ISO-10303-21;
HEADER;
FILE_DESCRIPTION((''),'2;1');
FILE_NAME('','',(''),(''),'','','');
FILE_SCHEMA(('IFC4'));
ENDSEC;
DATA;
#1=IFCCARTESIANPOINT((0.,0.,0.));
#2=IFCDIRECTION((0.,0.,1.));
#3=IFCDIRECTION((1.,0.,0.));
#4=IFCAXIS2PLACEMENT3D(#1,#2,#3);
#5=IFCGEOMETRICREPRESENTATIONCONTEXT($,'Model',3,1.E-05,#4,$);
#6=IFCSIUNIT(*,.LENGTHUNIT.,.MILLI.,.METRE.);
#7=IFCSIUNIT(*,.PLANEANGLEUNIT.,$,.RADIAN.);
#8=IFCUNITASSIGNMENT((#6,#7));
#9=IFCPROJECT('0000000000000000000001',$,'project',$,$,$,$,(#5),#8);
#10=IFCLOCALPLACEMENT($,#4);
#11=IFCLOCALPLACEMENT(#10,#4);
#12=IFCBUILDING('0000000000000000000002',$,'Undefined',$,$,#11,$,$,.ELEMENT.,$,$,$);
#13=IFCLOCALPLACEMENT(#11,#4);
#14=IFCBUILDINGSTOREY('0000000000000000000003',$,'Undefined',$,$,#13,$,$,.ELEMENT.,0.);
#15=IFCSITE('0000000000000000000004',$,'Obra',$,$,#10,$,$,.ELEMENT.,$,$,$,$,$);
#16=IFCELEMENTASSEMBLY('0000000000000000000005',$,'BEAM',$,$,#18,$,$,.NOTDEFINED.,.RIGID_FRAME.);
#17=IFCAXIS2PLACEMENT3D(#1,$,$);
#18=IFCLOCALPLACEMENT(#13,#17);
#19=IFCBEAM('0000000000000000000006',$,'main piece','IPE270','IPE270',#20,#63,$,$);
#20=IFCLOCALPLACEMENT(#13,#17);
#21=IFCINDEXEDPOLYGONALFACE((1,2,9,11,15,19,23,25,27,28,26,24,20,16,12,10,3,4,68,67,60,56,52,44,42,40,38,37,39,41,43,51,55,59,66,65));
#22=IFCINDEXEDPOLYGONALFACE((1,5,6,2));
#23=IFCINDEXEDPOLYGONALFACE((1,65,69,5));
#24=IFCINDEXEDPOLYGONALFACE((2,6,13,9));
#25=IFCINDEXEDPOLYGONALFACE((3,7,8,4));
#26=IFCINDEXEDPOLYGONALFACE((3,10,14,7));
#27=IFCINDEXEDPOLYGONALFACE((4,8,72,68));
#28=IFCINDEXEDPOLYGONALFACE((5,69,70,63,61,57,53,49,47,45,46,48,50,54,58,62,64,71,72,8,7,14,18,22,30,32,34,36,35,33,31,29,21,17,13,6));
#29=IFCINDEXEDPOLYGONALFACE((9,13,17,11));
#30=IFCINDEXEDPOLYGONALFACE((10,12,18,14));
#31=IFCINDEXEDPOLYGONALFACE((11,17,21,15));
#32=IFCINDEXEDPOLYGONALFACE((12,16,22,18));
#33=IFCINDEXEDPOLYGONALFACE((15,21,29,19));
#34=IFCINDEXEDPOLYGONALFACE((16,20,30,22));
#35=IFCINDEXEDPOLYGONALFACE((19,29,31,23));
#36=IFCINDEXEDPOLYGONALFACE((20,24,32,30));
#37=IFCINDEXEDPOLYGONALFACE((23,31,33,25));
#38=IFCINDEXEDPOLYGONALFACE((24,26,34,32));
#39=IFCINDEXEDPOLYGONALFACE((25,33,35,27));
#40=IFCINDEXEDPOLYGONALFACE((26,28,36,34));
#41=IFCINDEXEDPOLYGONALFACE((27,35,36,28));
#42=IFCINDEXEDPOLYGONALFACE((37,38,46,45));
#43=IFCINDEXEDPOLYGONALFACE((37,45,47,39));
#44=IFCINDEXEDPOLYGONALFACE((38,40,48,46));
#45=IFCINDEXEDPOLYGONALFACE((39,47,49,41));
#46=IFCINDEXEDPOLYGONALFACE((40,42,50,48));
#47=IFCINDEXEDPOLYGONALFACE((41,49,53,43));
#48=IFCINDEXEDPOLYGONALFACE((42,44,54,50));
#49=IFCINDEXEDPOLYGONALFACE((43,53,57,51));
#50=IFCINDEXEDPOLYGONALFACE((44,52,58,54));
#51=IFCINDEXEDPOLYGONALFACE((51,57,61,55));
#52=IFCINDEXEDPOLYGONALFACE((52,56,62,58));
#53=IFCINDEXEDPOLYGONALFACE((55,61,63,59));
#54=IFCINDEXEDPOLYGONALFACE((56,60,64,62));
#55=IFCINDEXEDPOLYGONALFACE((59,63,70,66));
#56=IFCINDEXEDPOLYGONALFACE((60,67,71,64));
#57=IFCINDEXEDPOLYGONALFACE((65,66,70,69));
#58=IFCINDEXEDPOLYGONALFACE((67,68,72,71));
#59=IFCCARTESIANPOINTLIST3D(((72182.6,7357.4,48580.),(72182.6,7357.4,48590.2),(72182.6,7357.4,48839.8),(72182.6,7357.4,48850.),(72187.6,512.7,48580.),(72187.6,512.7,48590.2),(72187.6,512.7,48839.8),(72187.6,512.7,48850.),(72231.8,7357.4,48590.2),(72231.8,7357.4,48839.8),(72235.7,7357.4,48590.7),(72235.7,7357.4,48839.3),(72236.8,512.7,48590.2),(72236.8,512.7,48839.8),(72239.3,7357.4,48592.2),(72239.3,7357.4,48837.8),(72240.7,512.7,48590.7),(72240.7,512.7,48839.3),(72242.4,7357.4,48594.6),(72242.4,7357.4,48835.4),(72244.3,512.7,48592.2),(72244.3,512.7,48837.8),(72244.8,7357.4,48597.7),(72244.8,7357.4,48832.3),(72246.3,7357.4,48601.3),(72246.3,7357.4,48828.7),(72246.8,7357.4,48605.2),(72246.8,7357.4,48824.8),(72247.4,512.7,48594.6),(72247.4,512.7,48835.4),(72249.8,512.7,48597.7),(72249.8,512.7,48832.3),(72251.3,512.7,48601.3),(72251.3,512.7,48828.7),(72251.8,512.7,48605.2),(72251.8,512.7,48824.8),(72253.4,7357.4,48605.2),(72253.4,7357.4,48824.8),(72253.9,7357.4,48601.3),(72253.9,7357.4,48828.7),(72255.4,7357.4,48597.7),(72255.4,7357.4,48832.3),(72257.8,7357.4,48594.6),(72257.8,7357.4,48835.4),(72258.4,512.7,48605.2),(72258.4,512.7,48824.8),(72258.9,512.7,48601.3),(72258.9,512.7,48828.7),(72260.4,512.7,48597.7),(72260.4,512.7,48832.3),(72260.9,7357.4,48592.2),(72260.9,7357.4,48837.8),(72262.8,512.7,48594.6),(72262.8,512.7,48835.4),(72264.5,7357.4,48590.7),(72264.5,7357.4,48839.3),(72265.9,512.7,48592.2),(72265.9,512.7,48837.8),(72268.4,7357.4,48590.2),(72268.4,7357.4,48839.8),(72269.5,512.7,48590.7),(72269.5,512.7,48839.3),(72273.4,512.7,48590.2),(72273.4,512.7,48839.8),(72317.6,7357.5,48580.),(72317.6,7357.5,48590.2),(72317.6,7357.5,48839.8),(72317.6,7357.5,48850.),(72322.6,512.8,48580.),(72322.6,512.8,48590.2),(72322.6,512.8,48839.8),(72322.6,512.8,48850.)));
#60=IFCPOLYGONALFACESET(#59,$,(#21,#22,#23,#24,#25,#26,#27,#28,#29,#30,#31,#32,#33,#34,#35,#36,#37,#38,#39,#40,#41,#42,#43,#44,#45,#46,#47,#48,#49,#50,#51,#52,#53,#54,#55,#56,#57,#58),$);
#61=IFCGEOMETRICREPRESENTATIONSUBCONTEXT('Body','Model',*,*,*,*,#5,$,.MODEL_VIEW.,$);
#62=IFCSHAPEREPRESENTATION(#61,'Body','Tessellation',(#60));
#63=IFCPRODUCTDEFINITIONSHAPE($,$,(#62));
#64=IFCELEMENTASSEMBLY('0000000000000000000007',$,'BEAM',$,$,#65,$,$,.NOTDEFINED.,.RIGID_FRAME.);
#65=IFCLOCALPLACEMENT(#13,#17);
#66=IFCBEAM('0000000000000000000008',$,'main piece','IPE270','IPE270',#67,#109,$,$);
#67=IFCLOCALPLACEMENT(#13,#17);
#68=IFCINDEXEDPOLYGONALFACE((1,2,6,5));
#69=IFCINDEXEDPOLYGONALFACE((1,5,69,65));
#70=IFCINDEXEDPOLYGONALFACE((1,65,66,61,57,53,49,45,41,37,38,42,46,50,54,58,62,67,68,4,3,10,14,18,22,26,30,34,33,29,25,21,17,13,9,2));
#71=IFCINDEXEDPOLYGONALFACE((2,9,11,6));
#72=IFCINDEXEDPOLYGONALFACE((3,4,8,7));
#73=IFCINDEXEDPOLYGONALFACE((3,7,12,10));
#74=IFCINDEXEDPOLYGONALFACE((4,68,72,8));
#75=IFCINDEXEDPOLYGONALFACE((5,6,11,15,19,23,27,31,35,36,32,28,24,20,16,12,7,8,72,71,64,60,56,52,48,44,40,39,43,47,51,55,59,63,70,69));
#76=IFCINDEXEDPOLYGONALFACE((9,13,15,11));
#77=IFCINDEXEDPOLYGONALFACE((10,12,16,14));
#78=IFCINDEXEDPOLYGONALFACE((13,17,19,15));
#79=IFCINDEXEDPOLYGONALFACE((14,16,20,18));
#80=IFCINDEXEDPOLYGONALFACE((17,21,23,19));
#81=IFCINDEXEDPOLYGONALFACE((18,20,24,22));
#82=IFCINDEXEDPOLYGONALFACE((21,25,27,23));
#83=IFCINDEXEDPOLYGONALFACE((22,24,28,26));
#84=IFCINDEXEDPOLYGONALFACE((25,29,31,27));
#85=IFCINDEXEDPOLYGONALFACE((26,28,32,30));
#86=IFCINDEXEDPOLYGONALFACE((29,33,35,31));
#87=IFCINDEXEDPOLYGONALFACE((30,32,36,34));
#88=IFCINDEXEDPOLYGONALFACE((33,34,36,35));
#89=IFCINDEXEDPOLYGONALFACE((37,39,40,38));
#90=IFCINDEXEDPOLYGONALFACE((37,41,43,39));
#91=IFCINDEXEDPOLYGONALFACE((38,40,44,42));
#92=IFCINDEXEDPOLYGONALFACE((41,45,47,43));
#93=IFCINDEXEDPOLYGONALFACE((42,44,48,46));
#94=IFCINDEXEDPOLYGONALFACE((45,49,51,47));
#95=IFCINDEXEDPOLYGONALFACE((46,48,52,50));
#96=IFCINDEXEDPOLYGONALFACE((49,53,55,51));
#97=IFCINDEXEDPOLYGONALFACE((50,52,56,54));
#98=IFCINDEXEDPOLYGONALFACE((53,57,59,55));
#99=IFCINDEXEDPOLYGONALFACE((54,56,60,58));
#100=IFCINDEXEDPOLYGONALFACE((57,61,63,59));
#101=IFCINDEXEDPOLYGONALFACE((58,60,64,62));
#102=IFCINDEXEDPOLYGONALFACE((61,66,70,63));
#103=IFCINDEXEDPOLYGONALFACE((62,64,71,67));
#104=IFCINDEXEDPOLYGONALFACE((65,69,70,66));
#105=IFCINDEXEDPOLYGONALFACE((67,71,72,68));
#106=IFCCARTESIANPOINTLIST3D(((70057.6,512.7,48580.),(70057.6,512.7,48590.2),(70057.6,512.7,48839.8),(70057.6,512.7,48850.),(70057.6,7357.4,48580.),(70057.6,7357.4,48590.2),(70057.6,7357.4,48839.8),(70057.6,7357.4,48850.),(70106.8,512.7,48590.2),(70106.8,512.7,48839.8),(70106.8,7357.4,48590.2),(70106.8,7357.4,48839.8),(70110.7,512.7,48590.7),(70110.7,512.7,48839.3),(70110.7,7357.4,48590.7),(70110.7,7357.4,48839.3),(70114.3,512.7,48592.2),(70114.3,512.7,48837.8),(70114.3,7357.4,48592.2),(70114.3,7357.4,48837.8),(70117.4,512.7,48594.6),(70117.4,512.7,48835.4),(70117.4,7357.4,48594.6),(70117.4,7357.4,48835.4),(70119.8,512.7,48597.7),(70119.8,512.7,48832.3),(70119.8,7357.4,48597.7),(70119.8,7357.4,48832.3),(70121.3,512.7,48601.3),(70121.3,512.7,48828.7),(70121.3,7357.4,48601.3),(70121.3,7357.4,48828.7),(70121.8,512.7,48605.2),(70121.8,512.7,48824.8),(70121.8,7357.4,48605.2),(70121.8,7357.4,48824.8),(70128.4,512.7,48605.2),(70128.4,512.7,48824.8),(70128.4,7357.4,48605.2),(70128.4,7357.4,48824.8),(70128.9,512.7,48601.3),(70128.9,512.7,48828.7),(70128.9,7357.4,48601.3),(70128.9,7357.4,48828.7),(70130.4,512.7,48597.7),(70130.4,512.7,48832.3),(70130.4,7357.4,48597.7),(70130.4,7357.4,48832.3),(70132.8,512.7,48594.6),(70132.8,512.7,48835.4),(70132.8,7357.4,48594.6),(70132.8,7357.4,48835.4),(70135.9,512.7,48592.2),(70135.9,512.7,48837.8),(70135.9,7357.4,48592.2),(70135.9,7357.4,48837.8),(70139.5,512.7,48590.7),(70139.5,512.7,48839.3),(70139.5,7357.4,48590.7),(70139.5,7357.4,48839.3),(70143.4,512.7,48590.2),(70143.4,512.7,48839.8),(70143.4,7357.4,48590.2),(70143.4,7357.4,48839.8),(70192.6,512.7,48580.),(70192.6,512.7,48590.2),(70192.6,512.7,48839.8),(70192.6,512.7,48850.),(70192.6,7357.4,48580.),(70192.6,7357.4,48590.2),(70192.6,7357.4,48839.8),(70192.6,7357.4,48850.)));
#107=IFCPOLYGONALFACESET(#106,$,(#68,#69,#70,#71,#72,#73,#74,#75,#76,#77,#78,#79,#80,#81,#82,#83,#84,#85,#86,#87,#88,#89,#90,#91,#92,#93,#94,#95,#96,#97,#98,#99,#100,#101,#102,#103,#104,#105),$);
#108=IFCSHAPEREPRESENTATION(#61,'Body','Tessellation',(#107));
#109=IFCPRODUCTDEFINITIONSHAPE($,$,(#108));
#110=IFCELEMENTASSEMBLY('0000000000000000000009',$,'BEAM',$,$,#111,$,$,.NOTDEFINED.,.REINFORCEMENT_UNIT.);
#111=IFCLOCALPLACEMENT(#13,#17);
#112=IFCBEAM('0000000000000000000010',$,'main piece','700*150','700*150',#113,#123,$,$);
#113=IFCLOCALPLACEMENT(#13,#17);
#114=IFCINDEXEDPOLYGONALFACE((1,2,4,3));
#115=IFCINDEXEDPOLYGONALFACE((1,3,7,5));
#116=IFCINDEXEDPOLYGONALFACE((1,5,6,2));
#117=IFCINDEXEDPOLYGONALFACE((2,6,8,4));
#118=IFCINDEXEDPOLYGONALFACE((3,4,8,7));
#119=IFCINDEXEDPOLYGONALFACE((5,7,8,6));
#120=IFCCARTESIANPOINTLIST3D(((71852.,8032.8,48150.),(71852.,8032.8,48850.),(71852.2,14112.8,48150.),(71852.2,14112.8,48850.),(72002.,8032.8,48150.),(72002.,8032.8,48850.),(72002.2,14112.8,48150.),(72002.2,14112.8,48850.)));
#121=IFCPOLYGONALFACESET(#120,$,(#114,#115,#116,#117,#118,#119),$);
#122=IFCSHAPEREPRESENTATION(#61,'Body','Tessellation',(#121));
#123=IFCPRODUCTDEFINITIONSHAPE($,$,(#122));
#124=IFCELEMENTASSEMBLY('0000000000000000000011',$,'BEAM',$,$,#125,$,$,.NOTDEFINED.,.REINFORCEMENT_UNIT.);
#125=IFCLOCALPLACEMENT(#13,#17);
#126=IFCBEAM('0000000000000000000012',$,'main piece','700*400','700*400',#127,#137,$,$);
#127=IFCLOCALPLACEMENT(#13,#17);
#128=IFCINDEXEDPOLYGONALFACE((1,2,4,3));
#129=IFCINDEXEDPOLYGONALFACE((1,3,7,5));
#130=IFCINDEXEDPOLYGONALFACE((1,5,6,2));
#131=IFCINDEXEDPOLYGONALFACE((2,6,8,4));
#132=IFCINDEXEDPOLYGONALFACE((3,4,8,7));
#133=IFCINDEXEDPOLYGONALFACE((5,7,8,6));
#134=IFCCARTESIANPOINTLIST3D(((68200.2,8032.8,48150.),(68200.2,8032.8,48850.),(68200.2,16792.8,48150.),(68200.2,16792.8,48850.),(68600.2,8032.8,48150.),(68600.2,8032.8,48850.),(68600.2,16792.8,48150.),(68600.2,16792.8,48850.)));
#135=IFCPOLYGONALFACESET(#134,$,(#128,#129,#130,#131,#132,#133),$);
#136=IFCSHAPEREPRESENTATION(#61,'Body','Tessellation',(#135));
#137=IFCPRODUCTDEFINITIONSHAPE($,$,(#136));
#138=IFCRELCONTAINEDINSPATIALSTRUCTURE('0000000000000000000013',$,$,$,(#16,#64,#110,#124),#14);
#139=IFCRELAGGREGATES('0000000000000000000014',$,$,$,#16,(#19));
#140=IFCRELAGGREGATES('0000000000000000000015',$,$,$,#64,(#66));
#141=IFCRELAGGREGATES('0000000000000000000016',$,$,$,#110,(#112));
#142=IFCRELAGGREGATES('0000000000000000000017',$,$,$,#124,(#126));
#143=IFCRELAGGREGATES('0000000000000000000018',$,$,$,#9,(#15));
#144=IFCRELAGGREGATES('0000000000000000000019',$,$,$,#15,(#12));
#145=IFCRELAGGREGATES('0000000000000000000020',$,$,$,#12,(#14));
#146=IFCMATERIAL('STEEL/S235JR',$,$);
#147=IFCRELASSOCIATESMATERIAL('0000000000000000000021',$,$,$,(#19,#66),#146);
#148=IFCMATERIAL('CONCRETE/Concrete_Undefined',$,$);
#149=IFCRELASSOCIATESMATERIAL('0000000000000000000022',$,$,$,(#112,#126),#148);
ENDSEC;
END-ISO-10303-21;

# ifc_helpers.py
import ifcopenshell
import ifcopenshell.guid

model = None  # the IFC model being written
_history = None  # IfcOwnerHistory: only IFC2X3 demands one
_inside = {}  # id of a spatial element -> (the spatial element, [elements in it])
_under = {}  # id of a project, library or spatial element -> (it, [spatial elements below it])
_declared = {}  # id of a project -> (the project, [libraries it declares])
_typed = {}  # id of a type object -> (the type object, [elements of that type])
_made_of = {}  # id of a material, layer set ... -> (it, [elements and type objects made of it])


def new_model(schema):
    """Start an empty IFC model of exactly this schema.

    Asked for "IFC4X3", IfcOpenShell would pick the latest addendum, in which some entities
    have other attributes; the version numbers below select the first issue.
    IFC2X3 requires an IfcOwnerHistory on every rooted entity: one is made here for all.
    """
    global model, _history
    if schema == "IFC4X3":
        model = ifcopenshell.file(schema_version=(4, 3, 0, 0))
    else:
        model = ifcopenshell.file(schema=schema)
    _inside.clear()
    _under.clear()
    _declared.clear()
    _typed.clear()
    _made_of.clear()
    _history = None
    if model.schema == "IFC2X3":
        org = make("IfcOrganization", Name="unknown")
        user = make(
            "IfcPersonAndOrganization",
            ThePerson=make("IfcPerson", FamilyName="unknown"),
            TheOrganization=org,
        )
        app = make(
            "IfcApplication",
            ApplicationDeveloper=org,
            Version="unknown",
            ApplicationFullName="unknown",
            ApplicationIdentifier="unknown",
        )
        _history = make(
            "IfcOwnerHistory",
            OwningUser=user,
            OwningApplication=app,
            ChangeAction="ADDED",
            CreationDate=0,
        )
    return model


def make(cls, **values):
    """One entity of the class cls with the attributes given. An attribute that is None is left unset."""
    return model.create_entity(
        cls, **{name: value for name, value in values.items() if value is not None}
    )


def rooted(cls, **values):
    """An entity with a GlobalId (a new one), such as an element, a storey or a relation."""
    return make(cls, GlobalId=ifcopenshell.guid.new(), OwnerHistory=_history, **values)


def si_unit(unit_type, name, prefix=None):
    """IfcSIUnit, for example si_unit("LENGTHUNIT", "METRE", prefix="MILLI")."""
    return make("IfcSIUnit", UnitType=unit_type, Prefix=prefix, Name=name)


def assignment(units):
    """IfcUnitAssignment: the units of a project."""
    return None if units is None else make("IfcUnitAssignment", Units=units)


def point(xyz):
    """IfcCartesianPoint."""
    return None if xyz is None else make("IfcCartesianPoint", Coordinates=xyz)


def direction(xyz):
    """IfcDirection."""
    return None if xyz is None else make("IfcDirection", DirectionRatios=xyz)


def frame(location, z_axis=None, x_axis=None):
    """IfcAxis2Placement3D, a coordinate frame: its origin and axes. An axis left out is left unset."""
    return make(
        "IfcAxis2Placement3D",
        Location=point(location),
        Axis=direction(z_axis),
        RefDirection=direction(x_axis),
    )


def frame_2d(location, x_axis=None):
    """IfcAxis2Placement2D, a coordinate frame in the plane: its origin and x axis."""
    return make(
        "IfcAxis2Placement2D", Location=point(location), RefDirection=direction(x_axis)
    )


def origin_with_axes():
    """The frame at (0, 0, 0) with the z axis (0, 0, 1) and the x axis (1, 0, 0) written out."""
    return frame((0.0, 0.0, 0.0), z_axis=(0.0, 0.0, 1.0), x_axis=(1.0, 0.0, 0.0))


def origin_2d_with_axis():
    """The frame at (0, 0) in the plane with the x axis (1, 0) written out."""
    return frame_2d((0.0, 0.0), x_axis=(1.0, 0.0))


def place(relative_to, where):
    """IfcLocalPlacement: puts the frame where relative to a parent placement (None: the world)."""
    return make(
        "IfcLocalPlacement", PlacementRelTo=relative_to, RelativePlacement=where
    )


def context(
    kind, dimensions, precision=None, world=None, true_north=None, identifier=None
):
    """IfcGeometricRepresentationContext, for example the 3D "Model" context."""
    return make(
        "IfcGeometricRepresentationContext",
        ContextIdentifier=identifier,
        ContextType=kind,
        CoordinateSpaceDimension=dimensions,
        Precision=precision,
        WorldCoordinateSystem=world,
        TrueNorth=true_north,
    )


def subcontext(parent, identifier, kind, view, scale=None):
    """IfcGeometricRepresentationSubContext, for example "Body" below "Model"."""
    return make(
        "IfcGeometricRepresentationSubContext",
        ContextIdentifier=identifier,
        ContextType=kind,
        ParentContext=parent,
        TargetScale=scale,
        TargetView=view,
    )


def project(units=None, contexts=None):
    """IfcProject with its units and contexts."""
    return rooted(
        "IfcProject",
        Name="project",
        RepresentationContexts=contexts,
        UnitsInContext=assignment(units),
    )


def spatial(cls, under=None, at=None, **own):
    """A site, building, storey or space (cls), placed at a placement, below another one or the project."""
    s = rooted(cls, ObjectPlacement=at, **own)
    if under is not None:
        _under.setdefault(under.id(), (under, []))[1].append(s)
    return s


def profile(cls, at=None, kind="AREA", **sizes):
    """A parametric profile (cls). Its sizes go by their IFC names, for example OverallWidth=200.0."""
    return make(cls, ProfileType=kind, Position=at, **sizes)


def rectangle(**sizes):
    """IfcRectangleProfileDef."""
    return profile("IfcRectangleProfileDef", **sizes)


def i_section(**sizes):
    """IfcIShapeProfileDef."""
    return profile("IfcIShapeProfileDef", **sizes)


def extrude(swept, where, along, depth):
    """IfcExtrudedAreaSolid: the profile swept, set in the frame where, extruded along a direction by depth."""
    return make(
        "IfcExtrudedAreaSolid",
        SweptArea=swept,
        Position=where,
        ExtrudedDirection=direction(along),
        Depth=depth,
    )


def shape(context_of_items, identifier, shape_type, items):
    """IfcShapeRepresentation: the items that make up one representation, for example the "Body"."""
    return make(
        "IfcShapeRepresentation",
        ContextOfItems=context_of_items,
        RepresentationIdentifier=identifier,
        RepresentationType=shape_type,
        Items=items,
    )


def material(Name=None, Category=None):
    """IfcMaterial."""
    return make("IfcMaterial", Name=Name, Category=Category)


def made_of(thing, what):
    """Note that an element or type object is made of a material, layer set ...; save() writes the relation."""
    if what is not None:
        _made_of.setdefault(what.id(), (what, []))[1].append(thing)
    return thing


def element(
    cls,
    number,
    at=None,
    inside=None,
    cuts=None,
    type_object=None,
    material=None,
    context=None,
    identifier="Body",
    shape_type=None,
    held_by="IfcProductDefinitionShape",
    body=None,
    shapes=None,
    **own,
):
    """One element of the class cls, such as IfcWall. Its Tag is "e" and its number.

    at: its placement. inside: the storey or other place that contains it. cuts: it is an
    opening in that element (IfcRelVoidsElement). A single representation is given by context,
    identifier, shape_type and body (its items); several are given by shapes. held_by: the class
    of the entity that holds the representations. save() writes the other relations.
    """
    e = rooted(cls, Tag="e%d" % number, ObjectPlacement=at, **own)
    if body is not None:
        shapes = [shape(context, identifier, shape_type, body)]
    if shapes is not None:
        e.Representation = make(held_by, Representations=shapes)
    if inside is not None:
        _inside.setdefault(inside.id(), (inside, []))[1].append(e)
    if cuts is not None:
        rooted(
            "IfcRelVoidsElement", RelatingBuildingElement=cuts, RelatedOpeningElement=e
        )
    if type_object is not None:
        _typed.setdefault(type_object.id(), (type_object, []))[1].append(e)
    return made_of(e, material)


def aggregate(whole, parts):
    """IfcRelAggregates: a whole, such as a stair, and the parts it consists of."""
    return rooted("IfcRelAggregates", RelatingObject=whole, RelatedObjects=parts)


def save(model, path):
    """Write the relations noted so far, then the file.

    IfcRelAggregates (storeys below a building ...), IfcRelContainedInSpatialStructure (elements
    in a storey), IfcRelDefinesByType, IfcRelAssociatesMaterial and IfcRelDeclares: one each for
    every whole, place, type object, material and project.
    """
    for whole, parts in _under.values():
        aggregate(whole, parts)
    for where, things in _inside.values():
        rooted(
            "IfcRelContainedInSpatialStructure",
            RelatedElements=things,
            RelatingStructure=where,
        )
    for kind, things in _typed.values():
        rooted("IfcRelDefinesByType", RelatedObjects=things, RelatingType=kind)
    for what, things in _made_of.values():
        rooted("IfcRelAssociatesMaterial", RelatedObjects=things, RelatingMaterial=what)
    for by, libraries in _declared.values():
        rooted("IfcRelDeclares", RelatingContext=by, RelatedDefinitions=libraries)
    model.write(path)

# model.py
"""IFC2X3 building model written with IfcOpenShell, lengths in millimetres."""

from ifc_helpers import new_model, si_unit, frame, origin_with_axes, origin_2d_with_axis, place, context, subcontext, project, spatial, rectangle, i_section, extrude, material, element, aggregate, save


model = new_model("IFC2X3")

# Units and contexts
model_context = context("Model", 3, precision=1e-05, world=origin_with_axes())
body_context = subcontext(model_context, "Body", "Model", "MODEL_VIEW")
ifc_project = project(units=[si_unit("LENGTHUNIT", "METRE", prefix="MILLI"), si_unit("PLANEANGLEUNIT", "RADIAN")], contexts=[model_context])

# Site, building, storey
site_placement = place(None, origin_with_axes())
site = spatial("IfcSite", under=ifc_project, at=site_placement, Name="Obra", CompositionType="ELEMENT")
building_placement = place(site_placement, origin_with_axes())
building = spatial("IfcBuilding", under=site, at=building_placement, Name="Undefined", CompositionType="ELEMENT")
storey_placement = place(building_placement, origin_with_axes())
storey = spatial("IfcBuildingStorey", under=building, at=storey_placement, Name="Undefined", CompositionType="ELEMENT", Elevation=0.0)

# Shared definitions
ifc_material_1 = material(Name="STEEL/S235JR")

# Element assemblies, beams
ifc_material_2 = material(Name="CONCRETE/Concrete_Undefined")
assembly_1_placement = place(storey_placement, origin_with_axes())
assembly_1 = element("IfcElementAssembly", 1, at=assembly_1_placement, inside=storey, Name="BEAM", AssemblyPlace="NOTDEFINED", PredefinedType="RIGID_FRAME")
beam_1_placement = place(assembly_1_placement, frame((72250.1, 7357.4, 48715.0), z_axis=(0.0, 0.0, 1.0), x_axis=(0.000731, -1.0, 0.0)))
beam_1 = element("IfcBeam", 2, at=beam_1_placement, material=ifc_material_1, Name="main piece", Description="IPE270", ObjectType="IPE270", context=body_context, shape_type="SweptSolid", body=[
    extrude(i_section(OverallWidth=135.0, OverallDepth=270.0, WebThickness=6.6, FlangeThickness=10.2, FilletRadius=15.0, at=origin_2d_with_axis()), frame((6844.7, 0.0, 0.0), z_axis=(-1.0, 0.0, 0.0), x_axis=(0.0, -1.0, 0.0)), (0.0, 0.0, 1.0), 6844.7),
])
aggregate(assembly_1, [beam_1])
assembly_2_placement = place(storey_placement, origin_with_axes())
assembly_2 = element("IfcElementAssembly", 3, at=assembly_2_placement, inside=storey, Name="BEAM", AssemblyPlace="NOTDEFINED", PredefinedType="RIGID_FRAME")
beam_2_placement = place(assembly_2_placement, frame((70125.1, 512.7, 48715.0), z_axis=(0.0, 0.0, 1.0), x_axis=(0.0, 1.0, 0.0)))
beam_2 = element("IfcBeam", 4, at=beam_2_placement, material=ifc_material_1, Name="main piece", Description="IPE270", ObjectType="IPE270", context=body_context, shape_type="SweptSolid", body=[
    extrude(i_section(OverallWidth=135.0, OverallDepth=270.0, WebThickness=6.6, FlangeThickness=10.2, FilletRadius=15.0, at=origin_2d_with_axis()), frame((6844.7, 0.0, 0.0), z_axis=(-1.0, 0.0, 0.0), x_axis=(0.0, -1.0, 0.0)), (0.0, 0.0, 1.0), 6844.7),
])
aggregate(assembly_2, [beam_2])
assembly_3_placement = place(storey_placement, origin_with_axes())
assembly_3 = element("IfcElementAssembly", 5, at=assembly_3_placement, inside=storey, Name="BEAM", AssemblyPlace="NOTDEFINED", PredefinedType="REINFORCEMENT_UNIT")
beam_3_placement = place(assembly_3_placement, frame((71927.0, 8032.8, 48500.0), z_axis=(0.0, 0.0, 1.0), x_axis=(0.000033, 1.0, 0.0)))
beam_3 = element("IfcBeam", 6, at=beam_3_placement, material=ifc_material_2, Name="main piece", Description="700*150", ObjectType="700*150", context=body_context, shape_type="SweptSolid", body=[
    extrude(rectangle(XDim=150.0, YDim=700.0, at=origin_2d_with_axis()), frame((6080.0, 0.0, 0.0), z_axis=(-1.0, 0.0, 0.0), x_axis=(0.0, -1.0, 0.0)), (0.0, 0.0, 1.0), 6080.0),
])
aggregate(assembly_3, [beam_3])
assembly_4_placement = place(storey_placement, origin_with_axes())
assembly_4 = element("IfcElementAssembly", 7, at=assembly_4_placement, inside=storey, Name="BEAM", AssemblyPlace="NOTDEFINED", PredefinedType="REINFORCEMENT_UNIT")
beam_4_placement = place(assembly_4_placement, frame((68400.2, 8032.8, 48500.0), z_axis=(0.0, 0.0, 1.0), x_axis=(0.0, 1.0, 0.0)))
beam_4 = element("IfcBeam", 8, at=beam_4_placement, material=ifc_material_2, Name="main piece", Description="700*400", ObjectType="700*400", context=body_context, shape_type="SweptSolid", body=[
    extrude(rectangle(XDim=400.0, YDim=700.0, at=origin_2d_with_axis()), frame((8760.0, 0.0, 0.0), z_axis=(-1.0, 0.0, 0.0), x_axis=(0.0, -1.0, 0.0)), (0.0, 0.0, 1.0), 8760.0),
])
aggregate(assembly_4, [beam_4])

save(model, "model.ifc")
